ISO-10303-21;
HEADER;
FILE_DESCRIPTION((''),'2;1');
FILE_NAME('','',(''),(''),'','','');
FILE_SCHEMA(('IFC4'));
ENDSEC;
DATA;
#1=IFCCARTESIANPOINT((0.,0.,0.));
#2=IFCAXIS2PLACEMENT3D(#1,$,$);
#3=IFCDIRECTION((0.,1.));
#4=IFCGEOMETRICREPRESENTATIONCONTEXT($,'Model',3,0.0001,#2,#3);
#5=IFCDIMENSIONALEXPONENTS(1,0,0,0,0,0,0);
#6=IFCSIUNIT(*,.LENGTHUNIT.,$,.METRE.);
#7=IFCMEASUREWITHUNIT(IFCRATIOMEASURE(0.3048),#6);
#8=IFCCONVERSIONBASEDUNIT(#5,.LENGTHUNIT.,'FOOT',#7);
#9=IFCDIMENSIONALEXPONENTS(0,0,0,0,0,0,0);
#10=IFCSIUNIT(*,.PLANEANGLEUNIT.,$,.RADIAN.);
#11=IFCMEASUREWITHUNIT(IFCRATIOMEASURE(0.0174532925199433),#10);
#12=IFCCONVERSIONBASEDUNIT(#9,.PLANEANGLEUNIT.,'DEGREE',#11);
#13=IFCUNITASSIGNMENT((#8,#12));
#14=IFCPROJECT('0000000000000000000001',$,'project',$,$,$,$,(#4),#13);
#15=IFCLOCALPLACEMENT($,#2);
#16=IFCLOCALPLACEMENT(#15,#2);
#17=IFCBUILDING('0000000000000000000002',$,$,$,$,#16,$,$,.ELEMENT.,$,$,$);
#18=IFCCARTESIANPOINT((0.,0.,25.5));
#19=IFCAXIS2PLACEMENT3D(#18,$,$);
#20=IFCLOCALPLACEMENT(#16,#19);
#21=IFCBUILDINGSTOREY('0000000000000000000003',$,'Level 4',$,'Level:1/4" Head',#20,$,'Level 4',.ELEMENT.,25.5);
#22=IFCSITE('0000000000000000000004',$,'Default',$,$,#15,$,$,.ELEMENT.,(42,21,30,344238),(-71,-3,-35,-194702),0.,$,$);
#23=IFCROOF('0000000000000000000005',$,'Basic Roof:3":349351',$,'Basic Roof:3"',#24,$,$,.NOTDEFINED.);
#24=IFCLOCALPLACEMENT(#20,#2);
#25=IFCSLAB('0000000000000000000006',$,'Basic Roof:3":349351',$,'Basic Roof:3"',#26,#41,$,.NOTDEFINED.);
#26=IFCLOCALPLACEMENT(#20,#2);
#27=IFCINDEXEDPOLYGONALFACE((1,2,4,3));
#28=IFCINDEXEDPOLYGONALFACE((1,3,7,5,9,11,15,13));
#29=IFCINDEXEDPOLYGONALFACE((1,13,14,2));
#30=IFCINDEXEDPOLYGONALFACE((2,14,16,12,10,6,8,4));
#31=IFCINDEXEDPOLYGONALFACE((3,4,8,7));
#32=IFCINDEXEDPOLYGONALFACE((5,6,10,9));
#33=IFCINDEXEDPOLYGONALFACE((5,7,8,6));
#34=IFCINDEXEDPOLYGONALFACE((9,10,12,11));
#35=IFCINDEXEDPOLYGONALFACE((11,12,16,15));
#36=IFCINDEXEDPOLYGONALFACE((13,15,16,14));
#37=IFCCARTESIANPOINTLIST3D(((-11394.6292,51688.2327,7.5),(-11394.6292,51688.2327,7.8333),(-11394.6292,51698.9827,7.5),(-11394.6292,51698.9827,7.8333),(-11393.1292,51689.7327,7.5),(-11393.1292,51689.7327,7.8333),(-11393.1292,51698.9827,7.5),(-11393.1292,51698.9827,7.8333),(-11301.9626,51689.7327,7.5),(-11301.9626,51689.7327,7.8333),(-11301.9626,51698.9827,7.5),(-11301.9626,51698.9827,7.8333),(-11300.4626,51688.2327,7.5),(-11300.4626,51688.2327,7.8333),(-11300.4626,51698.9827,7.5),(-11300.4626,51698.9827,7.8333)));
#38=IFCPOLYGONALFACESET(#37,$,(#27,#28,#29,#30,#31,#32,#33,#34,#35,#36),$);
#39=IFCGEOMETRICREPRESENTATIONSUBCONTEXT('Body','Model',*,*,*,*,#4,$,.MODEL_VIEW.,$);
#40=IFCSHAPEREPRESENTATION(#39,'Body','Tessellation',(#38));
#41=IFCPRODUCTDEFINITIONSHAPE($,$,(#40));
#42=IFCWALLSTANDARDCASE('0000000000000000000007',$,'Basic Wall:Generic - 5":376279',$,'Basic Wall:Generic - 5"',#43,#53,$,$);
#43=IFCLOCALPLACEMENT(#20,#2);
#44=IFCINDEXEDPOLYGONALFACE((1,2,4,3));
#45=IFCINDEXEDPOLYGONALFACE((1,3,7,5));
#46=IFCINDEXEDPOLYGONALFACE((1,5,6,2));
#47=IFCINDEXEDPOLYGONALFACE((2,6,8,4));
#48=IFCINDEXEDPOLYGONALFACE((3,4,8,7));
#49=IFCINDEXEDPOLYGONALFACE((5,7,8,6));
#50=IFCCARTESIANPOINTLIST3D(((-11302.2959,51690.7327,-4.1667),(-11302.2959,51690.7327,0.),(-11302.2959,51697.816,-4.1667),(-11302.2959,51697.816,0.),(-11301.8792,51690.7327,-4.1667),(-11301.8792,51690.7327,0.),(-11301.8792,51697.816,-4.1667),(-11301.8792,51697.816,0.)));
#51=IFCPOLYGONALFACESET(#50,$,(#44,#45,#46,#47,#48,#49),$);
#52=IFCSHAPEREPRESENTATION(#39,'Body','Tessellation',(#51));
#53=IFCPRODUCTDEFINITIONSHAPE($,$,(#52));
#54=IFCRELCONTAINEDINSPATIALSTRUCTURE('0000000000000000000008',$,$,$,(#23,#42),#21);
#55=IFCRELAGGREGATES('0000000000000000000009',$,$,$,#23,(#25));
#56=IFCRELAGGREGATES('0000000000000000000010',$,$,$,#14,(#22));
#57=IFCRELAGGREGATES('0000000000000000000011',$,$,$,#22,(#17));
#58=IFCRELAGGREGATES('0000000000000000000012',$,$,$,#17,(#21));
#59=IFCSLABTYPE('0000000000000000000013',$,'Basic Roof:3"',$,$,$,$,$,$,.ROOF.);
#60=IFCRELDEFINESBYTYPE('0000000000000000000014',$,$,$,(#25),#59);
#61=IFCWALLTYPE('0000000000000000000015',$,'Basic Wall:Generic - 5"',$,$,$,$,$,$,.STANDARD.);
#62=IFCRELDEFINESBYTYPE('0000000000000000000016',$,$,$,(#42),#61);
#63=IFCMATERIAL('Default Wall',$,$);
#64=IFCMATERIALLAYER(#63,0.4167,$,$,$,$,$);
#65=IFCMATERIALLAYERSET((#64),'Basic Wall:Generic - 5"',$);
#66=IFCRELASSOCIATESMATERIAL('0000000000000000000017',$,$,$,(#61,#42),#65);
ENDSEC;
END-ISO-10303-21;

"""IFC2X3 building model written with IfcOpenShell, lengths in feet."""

from ifc_helpers import new_model, entity, si_unit, converted_unit, direction, frame, frame_2d, origin, place, context, subcontext, project, spatial, polyline, rectangle, outline, extrude, material, layer, layer_set, layer_usage, type_object, element, aggregate, save


model = new_model("IFC2X3")

# Units and contexts
model_context = context("Model", 3, precision=0.0001, world=origin(), true_north=direction((0.0, 1.0)))
body_context = subcontext(model_context, "Body", "Model", "MODEL_VIEW")
ifc_project = project(units=[converted_unit("LENGTHUNIT", "FOOT", entity("IfcRatioMeasure", 0.3048), si_unit("LENGTHUNIT", "METRE"), dimensions=[1, 0, 0, 0, 0, 0, 0]), converted_unit("PLANEANGLEUNIT", "DEGREE", entity("IfcRatioMeasure", 0.0174532925199433), si_unit("PLANEANGLEUNIT", "RADIAN"), dimensions=[0, 0, 0, 0, 0, 0, 0])], contexts=[model_context])

# Site, building, storey
site_placement = place(None, origin())
site = spatial("IfcSite", under=ifc_project, at=site_placement, Name="Default", CompositionType="ELEMENT", RefLatitude=(42, 21, 30, 344238), RefLongitude=(-71, -3, -35, -194702), RefElevation=0.0)
building_placement = place(site_placement, origin())
building = spatial("IfcBuilding", under=site, at=building_placement, CompositionType="ELEMENT")
storey_placement = place(building_placement, frame((0.0, 0.0, 25.5)))
storey = spatial("IfcBuildingStorey", under=building, at=storey_placement, Name="Level 4", ObjectType="Level:1/4\" Head", LongName="Level 4", CompositionType="ELEMENT", Elevation=25.5)

# Roof, slab
roof_1_placement = place(storey_placement, frame((-11394.6292, 51688.2327, 7.5)))
roof_1 = element("IfcRoof", 1, at=roof_1_placement, inside=storey, Name="Basic Roof:3\":349351", ObjectType="Basic Roof:3\"", ShapeType="NOTDEFINED")
slab_type_1 = type_object("IfcSlabType", Name="Basic Roof:3\"", PredefinedType="ROOF")
slab_1_placement = place(roof_1_placement, origin())
slab_1 = element("IfcSlab", 2, at=slab_1_placement, type_object=slab_type_1, Name="Basic Roof:3\":349351", ObjectType="Basic Roof:3\"", PredefinedType="NOTDEFINED", context=body_context, shape_type="SweptSolid", body=[
    extrude(outline(polyline([(45.5833, -3.875), (-45.5833, -3.875), (-45.5833, 5.375), (-47.0833, 5.375), (-47.0833, -5.375), (47.0833, -5.375), (47.0833, 5.375), (45.5833, 5.375), (45.5833, -3.875)])), frame((47.0833, 5.375, 0.0)), (0.0, 0.0, 1.0), 0.3333),
])
aggregate(roof_1, [slab_1])

# Wall
ifc_material = material(Name="Default Wall")
ifc_layer = layer(ifc_material, 0.4167)
ifc_layer_set = layer_set([ifc_layer], Name="Basic Wall:Generic - 5\"")
ifc_layer_usage = layer_usage(ifc_layer_set, "AXIS2", "POSITIVE", -0.2083)
wall_type = type_object("IfcWallType", Name="Basic Wall:Generic - 5\"", PredefinedType="STANDARD", material=ifc_layer_set)
wall_placement = place(storey_placement, frame((-11302.0876, 51690.7327, -4.1667), z_axis=(0.0, 0.0, 1.0), x_axis=(0.0, 1.0, 0.0)))
element("IfcWallStandardCase", 3, at=wall_placement, inside=storey, type_object=wall_type, material=ifc_layer_usage, Name="Basic Wall:Generic - 5\":376279", ObjectType="Basic Wall:Generic - 5\"", context=body_context, shape_type="SweptSolid", body=[
    extrude(rectangle(XDim=7.0833, YDim=0.4167, at=frame_2d((3.5417, 0.0), x_axis=(-1.0, 0.0))), origin(), (0.0, 0.0, 1.0), 4.1667),
])

save(model, "model.ifc")
